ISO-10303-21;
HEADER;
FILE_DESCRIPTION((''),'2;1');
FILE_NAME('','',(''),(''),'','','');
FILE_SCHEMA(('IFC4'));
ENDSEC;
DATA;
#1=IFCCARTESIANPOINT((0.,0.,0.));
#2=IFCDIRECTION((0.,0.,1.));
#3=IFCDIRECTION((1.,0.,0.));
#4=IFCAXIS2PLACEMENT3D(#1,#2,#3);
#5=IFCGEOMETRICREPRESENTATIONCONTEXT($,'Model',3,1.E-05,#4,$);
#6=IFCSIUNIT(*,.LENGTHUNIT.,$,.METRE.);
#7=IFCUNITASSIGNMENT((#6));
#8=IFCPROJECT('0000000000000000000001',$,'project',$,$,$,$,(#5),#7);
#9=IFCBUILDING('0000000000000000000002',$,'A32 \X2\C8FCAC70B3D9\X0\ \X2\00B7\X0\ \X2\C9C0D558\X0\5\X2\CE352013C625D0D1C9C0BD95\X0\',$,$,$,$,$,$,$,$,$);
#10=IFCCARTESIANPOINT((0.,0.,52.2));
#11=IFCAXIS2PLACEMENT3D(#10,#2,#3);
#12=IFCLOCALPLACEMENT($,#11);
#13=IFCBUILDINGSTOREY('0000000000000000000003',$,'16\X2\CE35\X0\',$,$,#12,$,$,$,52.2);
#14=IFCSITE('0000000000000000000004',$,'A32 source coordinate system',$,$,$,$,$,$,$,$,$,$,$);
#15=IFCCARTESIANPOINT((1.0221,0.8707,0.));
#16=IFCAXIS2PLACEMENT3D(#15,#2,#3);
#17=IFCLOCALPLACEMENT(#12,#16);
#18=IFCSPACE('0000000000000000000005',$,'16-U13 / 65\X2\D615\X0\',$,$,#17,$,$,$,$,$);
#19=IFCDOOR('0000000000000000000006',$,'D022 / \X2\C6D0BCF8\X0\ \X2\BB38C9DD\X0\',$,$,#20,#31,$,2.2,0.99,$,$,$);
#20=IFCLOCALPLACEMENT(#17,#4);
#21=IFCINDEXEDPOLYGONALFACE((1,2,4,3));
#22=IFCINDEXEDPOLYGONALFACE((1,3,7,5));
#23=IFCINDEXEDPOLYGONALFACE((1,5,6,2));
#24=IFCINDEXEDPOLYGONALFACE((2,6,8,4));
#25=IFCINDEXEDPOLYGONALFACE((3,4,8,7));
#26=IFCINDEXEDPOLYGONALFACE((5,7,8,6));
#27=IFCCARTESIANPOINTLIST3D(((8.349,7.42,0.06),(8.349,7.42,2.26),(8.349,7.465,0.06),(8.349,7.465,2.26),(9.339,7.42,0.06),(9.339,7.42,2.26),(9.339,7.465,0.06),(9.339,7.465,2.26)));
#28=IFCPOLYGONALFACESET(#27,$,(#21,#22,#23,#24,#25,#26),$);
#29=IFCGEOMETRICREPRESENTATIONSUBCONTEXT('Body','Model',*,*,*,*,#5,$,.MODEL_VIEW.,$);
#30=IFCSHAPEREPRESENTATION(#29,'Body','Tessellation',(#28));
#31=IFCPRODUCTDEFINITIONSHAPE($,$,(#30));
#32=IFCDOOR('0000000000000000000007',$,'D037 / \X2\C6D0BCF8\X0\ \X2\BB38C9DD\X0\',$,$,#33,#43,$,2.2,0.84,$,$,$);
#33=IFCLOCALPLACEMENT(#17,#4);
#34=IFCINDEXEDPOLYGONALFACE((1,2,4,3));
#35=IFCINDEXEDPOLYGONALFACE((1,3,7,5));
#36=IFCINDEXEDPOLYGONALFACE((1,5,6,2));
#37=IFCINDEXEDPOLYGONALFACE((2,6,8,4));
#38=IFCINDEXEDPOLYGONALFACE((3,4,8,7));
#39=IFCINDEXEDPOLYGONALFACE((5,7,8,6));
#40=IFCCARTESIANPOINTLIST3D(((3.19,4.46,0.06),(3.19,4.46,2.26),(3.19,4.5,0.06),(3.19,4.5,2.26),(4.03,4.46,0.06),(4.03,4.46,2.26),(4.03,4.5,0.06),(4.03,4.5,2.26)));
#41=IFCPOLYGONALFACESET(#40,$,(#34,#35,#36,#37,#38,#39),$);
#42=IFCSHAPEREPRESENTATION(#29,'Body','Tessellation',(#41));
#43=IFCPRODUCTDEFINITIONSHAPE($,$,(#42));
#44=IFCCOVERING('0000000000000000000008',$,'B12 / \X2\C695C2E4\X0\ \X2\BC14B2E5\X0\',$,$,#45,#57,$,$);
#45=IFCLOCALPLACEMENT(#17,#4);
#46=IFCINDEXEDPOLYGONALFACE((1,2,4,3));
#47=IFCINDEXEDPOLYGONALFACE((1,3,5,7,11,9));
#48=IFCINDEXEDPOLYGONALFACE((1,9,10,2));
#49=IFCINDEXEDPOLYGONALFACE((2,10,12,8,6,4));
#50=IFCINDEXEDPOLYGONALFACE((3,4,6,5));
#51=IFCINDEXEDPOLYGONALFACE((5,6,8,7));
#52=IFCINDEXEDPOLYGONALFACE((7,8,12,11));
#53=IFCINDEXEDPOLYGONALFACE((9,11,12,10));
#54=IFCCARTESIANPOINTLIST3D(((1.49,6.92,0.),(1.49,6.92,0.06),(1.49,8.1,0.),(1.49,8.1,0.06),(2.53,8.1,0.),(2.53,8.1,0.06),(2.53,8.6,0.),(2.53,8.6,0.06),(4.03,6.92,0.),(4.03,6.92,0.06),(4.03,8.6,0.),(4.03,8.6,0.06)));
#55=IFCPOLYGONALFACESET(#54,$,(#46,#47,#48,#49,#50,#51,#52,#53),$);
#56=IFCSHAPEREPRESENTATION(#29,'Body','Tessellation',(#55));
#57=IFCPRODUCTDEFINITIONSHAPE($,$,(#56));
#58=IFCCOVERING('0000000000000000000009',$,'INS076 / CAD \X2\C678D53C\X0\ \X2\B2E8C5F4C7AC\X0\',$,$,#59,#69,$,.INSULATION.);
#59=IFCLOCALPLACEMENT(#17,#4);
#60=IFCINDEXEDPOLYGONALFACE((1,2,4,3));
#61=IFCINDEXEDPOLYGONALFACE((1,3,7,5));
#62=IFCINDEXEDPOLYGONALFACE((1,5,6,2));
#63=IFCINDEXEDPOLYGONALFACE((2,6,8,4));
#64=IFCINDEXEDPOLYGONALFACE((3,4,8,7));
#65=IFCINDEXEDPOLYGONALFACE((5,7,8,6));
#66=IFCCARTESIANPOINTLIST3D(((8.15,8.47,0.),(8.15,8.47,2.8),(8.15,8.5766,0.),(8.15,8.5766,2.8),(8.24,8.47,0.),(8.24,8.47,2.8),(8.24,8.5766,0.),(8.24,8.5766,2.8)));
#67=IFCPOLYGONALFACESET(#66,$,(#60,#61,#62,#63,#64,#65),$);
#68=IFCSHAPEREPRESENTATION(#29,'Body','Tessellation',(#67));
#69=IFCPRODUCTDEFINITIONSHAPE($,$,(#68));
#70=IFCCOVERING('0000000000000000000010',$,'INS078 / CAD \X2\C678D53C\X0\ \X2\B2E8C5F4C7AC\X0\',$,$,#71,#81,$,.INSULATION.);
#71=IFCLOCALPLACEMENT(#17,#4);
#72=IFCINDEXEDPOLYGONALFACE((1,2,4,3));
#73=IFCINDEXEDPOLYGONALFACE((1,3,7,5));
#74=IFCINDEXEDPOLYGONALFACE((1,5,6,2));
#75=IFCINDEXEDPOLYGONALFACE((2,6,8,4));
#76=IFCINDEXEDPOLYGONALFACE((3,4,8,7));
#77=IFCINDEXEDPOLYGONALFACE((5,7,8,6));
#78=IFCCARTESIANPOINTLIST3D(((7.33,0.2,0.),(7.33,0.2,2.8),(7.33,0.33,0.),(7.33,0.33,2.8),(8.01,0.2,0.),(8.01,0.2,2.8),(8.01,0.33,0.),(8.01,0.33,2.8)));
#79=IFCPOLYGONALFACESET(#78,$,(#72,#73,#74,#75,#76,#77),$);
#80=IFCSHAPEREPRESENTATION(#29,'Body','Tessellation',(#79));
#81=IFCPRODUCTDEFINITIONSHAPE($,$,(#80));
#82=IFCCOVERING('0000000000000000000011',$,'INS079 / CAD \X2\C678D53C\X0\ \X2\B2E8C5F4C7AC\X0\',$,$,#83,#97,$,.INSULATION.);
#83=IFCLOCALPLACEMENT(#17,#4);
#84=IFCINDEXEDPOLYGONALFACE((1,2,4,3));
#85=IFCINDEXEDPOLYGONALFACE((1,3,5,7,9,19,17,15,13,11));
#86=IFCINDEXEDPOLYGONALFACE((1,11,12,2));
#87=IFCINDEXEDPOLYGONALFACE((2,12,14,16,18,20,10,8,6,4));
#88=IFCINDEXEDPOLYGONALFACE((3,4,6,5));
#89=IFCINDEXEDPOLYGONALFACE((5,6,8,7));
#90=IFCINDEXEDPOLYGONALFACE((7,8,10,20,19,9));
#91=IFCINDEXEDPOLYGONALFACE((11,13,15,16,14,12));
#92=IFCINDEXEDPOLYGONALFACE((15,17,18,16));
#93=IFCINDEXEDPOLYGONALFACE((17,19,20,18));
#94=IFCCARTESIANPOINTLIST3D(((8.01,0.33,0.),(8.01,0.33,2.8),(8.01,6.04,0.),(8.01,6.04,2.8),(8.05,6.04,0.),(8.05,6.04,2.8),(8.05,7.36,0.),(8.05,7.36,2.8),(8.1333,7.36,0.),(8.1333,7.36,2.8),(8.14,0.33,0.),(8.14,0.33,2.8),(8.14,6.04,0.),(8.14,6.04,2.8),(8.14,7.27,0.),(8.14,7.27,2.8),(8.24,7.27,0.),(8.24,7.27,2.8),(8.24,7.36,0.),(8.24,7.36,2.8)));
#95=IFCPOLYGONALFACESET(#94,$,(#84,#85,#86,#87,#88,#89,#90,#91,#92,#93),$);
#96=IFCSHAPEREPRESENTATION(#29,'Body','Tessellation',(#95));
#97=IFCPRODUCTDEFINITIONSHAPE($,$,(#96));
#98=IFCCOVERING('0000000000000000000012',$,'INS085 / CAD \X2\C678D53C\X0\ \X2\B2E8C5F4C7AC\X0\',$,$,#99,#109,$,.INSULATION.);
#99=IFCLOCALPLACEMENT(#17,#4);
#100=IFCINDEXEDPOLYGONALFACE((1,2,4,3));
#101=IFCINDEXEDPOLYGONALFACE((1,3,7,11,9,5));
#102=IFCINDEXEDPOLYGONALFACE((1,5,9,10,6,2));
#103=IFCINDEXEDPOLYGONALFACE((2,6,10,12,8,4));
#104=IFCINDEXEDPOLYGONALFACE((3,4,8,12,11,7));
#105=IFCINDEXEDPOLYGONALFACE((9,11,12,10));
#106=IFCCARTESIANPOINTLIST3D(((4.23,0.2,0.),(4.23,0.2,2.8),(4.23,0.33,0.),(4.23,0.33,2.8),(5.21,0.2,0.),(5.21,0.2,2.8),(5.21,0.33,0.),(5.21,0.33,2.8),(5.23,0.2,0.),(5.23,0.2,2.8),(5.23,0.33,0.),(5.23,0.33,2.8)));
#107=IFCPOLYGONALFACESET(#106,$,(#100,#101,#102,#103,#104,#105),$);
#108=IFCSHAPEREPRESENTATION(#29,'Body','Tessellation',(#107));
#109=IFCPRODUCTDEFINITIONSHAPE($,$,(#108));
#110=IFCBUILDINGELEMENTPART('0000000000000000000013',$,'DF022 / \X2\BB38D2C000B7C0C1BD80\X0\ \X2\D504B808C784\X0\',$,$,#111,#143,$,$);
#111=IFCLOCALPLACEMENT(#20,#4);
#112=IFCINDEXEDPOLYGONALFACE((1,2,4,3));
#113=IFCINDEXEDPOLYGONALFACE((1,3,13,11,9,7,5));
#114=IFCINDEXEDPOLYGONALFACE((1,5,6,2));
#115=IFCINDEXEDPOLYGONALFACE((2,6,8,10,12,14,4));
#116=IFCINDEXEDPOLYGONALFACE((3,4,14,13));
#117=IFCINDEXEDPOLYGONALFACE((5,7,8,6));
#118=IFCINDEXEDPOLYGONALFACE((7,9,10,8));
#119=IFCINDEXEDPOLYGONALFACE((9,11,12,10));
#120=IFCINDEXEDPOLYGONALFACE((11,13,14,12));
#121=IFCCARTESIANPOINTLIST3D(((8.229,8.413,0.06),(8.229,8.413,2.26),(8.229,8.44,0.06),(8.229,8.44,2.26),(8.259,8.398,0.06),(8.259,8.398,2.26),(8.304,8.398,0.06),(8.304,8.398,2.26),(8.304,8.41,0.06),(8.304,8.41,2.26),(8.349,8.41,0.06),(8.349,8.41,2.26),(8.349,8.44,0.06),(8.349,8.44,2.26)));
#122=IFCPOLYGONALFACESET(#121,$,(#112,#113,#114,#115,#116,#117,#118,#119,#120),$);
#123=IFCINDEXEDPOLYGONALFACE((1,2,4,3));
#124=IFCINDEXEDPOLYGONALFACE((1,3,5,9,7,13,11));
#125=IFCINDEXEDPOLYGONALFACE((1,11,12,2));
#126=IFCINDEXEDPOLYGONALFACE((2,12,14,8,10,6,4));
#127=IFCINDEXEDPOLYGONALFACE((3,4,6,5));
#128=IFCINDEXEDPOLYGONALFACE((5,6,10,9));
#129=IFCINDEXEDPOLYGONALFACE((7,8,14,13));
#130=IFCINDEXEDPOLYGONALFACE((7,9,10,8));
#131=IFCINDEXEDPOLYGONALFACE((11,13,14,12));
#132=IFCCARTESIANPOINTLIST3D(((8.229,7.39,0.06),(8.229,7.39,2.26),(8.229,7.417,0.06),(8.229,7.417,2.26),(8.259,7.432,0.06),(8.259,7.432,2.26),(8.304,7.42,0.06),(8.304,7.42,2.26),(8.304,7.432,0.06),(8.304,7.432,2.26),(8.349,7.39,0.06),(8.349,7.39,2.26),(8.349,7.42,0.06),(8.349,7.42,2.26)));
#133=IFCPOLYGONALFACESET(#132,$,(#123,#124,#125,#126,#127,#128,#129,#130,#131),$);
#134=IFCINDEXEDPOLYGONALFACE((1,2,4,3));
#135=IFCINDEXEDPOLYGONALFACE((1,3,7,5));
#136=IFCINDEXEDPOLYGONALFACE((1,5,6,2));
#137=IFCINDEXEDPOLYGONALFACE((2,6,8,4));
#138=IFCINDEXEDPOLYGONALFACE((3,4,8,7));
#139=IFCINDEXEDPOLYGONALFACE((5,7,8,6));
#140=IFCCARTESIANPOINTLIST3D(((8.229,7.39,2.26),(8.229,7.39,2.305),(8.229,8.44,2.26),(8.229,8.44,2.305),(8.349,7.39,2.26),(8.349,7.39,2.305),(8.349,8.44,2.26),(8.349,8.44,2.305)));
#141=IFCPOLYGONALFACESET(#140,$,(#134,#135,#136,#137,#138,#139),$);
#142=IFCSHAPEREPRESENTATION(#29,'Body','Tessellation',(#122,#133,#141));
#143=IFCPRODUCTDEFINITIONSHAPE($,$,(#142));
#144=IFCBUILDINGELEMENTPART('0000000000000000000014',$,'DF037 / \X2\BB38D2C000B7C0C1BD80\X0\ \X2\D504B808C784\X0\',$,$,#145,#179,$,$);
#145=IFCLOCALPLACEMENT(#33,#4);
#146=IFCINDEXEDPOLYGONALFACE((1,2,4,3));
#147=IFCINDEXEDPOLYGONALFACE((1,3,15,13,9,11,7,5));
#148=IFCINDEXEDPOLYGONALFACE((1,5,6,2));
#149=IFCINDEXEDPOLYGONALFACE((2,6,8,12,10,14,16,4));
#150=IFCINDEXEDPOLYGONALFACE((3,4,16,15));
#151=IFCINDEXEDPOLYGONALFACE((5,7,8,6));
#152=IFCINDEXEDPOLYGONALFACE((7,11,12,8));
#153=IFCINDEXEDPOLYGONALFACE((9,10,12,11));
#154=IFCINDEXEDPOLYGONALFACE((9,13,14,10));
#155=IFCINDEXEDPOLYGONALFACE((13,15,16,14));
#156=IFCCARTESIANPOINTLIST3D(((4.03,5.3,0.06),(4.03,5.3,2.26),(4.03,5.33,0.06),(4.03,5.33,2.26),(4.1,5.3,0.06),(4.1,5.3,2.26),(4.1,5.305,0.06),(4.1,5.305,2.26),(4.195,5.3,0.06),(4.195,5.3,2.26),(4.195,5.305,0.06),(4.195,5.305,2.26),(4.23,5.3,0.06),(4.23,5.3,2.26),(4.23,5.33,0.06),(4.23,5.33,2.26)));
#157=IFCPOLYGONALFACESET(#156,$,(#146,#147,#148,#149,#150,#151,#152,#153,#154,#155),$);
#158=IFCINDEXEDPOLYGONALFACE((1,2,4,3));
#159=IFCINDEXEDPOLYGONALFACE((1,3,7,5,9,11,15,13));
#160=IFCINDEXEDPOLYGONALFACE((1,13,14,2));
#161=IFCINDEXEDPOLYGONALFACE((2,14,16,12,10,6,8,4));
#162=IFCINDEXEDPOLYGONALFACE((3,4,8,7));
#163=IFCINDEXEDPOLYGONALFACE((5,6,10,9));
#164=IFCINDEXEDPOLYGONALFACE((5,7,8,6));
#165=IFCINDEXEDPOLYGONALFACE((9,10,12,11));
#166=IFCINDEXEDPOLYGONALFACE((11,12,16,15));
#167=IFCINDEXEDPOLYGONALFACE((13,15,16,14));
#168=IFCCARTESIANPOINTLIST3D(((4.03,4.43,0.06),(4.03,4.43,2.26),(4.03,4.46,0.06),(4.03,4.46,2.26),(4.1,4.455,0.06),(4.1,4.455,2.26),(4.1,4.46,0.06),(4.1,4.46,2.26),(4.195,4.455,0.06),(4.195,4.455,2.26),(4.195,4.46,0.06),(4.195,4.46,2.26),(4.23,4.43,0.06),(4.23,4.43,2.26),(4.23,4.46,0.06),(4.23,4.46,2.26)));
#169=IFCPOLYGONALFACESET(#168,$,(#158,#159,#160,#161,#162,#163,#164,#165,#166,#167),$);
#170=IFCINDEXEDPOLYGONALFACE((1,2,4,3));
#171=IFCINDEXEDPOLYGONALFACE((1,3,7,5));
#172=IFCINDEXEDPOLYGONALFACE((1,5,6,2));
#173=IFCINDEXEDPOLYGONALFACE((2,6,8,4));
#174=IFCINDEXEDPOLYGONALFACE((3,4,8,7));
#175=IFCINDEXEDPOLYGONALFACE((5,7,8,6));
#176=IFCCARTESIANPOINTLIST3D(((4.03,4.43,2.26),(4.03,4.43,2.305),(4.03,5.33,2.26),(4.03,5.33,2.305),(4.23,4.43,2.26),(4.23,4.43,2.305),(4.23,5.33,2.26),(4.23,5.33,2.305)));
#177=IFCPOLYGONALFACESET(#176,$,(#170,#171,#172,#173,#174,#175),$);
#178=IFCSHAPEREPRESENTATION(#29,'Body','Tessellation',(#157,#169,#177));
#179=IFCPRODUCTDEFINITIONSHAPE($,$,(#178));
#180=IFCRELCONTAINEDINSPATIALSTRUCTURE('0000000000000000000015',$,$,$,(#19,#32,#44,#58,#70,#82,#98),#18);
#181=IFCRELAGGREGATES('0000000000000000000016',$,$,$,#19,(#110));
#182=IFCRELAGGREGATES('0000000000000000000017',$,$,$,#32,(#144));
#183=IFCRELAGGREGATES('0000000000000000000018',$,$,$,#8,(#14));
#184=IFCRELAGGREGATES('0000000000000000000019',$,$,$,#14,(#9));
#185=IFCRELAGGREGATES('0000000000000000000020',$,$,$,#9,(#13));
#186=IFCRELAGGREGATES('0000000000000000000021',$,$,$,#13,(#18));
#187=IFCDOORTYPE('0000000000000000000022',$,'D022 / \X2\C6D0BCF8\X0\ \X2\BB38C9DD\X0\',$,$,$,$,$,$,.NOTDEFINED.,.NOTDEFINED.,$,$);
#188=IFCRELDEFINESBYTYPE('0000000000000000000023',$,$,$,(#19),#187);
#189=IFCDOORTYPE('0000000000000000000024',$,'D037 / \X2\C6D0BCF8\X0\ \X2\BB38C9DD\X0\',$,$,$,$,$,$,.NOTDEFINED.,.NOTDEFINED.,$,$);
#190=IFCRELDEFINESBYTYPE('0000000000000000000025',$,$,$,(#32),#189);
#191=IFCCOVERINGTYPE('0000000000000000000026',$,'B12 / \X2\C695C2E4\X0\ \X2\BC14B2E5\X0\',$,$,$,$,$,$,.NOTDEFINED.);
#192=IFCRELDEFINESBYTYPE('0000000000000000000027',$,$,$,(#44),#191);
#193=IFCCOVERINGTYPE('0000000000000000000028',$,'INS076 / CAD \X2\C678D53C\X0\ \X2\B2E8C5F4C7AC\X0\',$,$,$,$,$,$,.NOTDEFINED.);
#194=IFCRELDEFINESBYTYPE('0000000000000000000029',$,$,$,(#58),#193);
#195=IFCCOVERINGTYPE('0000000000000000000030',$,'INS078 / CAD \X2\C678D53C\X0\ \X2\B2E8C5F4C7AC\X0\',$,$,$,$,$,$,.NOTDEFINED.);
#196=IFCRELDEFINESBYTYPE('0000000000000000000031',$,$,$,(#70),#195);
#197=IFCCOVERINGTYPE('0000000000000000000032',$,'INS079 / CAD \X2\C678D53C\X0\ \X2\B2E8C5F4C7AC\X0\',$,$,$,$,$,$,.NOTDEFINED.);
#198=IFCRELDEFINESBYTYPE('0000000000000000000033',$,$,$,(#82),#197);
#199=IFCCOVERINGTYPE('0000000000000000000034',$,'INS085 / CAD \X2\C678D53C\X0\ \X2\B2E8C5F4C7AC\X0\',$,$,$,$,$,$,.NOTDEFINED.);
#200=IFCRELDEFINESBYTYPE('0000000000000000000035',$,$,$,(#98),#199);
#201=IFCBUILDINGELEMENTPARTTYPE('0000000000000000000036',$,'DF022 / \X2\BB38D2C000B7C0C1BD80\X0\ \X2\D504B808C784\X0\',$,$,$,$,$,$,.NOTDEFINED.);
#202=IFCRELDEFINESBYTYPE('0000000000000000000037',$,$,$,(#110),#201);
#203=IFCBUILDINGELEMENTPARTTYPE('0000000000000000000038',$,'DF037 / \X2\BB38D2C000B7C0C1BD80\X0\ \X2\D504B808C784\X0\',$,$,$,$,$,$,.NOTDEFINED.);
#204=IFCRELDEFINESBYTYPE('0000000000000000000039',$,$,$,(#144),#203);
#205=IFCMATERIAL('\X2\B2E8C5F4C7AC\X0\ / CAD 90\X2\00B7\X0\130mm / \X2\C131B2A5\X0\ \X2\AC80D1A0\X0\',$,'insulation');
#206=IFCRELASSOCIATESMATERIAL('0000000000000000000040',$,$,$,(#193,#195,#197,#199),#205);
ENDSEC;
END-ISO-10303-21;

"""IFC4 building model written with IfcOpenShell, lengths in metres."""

from ifc_helpers import new_model, si_unit, frame, origin, origin_with_axes, place, context, subcontext, project, spatial, polyline, outline, extrude, source, transform, mapped, material, type_object, type_shapes, element, aggregate, save


model = new_model("IFC4")

# Units and contexts
model_context = context("Model", 3, precision=1e-05, world=origin_with_axes())
body_context = subcontext(model_context, "Body", "Model", "MODEL_VIEW")
ifc_project = project(units=[si_unit("LENGTHUNIT", "METRE")], contexts=[model_context])

# Site, building, storey
site = spatial("IfcSite", under=ifc_project, Name="A32 source coordinate system")
building = spatial("IfcBuilding", under=site, Name="A32 주거동 · 지하5층–옥탑지붕")
storey_placement = place(None, frame((0.0, 0.0, 52.2), z_axis=(0.0, 0.0, 1.0), x_axis=(1.0, 0.0, 0.0)))
storey = spatial("IfcBuildingStorey", under=building, at=storey_placement, Name="16층", Elevation=52.2)

# Shared definitions
space_placement = place(storey_placement, frame((1.0221, 0.8707, 0.0), z_axis=(0.0, 0.0, 1.0), x_axis=(1.0, 0.0, 0.0)))
space = spatial("IfcSpace", under=storey, at=space_placement, Name="16-U13 / 65형")

# Doors
door_type_1 = type_object("IfcDoorType", Name="D022 / 원본 문짝", OperationType="NOTDEFINED", PredefinedType="NOTDEFINED")
shared_shape_1 = source(origin(), body_context, "Body", "SweptSolid", [
    extrude(outline(polyline([(9.339, 7.465), (9.339, 7.42), (8.349, 7.42), (8.349, 7.465), (9.339, 7.465)])), frame((0.0, 0.0, 0.06)), (0.0, 0.0, 1.0), 2.2),
])
type_shapes(door_type_1, [shared_shape_1])
door_1_placement = place(space_placement, origin_with_axes())
door_1 = element("IfcDoor", 1, at=door_1_placement, inside=space, type_object=door_type_1, Name="D022 / 원본 문짝", OverallHeight=2.2, OverallWidth=0.99, context=body_context, shape_type="MappedRepresentation", body=[
    mapped(shared_shape_1, transform((0.0, 0.0, 0.0), scale=1.0)),
])
door_type_2 = type_object("IfcDoorType", Name="D037 / 원본 문짝", OperationType="NOTDEFINED", PredefinedType="NOTDEFINED")
shared_shape_2 = source(origin(), body_context, "Body", "SweptSolid", [
    extrude(outline(polyline([(4.03, 4.46), (3.19, 4.46), (3.19, 4.5), (4.03, 4.5), (4.03, 4.46)])), frame((0.0, 0.0, 0.06)), (0.0, 0.0, 1.0), 2.2),
])
type_shapes(door_type_2, [shared_shape_2])
door_2_placement = place(space_placement, origin_with_axes())
door_2 = element("IfcDoor", 2, at=door_2_placement, inside=space, type_object=door_type_2, Name="D037 / 원본 문짝", OverallHeight=2.2, OverallWidth=0.84, context=body_context, shape_type="MappedRepresentation", body=[
    mapped(shared_shape_2, transform((0.0, 0.0, 0.0), scale=1.0)),
])

# Coverings
covering_type_1 = type_object("IfcCoveringType", Name="B12 / 욕실 바닥", PredefinedType="NOTDEFINED")
shared_shape_3 = source(origin(), body_context, "Body", "SweptSolid", [
    extrude(outline(polyline([(2.53, 8.6), (4.03, 8.6), (4.03, 6.92), (1.49, 6.92), (1.49, 8.1), (2.53, 8.1), (2.53, 8.6)])), origin(), (0.0, 0.0, 1.0), 0.06),
])
type_shapes(covering_type_1, [shared_shape_3])
covering_1_placement = place(space_placement, origin_with_axes())
element("IfcCovering", 3, at=covering_1_placement, inside=space, type_object=covering_type_1, Name="B12 / 욕실 바닥", context=body_context, shape_type="MappedRepresentation", body=[
    mapped(shared_shape_3, transform((0.0, 0.0, 0.0), scale=1.0)),
])
ifc_material = material(Name="단열재 / CAD 90·130mm / 성능 검토", Category="insulation")
covering_type_2 = type_object("IfcCoveringType", Name="INS076 / CAD 외피 단열재", PredefinedType="NOTDEFINED", material=ifc_material)
shared_shape_4 = source(origin(), body_context, "Body", "SweptSolid", [
    extrude(outline(polyline([(8.24, 8.5766), (8.24, 8.47), (8.15, 8.47), (8.15, 8.5766), (8.24, 8.5766)])), origin(), (0.0, 0.0, 1.0), 2.8),
])
type_shapes(covering_type_2, [shared_shape_4])
covering_2_placement = place(space_placement, origin_with_axes())
element("IfcCovering", 4, at=covering_2_placement, inside=space, type_object=covering_type_2, Name="INS076 / CAD 외피 단열재", PredefinedType="INSULATION", context=body_context, shape_type="MappedRepresentation", body=[
    mapped(shared_shape_4, transform((0.0, 0.0, 0.0), scale=1.0)),
])
covering_type_3 = type_object("IfcCoveringType", Name="INS078 / CAD 외피 단열재", PredefinedType="NOTDEFINED", material=ifc_material)
shared_shape_5 = source(origin(), body_context, "Body", "SweptSolid", [
    extrude(outline(polyline([(8.01, 0.2), (7.33, 0.2), (7.33, 0.33), (8.01, 0.33), (8.01, 0.2)])), origin(), (0.0, 0.0, 1.0), 2.8),
])
type_shapes(covering_type_3, [shared_shape_5])
covering_3_placement = place(space_placement, origin_with_axes())
element("IfcCovering", 5, at=covering_3_placement, inside=space, type_object=covering_type_3, Name="INS078 / CAD 외피 단열재", PredefinedType="INSULATION", context=body_context, shape_type="MappedRepresentation", body=[
    mapped(shared_shape_5, transform((0.0, 0.0, 0.0), scale=1.0)),
])
covering_type_4 = type_object("IfcCoveringType", Name="INS079 / CAD 외피 단열재", PredefinedType="NOTDEFINED", material=ifc_material)
shared_shape_6 = source(origin(), body_context, "Body", "SweptSolid", [
    extrude(outline(polyline([(8.24, 7.27), (8.14, 7.27), (8.14, 6.04), (8.14, 0.33), (8.01, 0.33), (8.01, 6.04), (8.05, 6.04), (8.05, 7.36), (8.1333, 7.36), (8.24, 7.36), (8.24, 7.27)])), origin(), (0.0, 0.0, 1.0), 2.8),
])
type_shapes(covering_type_4, [shared_shape_6])
covering_4_placement = place(space_placement, origin_with_axes())
element("IfcCovering", 6, at=covering_4_placement, inside=space, type_object=covering_type_4, Name="INS079 / CAD 외피 단열재", PredefinedType="INSULATION", context=body_context, shape_type="MappedRepresentation", body=[
    mapped(shared_shape_6, transform((0.0, 0.0, 0.0), scale=1.0)),
])
covering_type_5 = type_object("IfcCoveringType", Name="INS085 / CAD 외피 단열재", PredefinedType="NOTDEFINED", material=ifc_material)
shared_shape_7 = source(origin(), body_context, "Body", "SweptSolid", [
    extrude(outline(polyline([(4.23, 0.2), (4.23, 0.33), (5.21, 0.33), (5.23, 0.33), (5.23, 0.2), (5.21, 0.2), (4.23, 0.2)])), origin(), (0.0, 0.0, 1.0), 2.8),
])
type_shapes(covering_type_5, [shared_shape_7])
covering_5_placement = place(space_placement, origin_with_axes())
element("IfcCovering", 7, at=covering_5_placement, inside=space, type_object=covering_type_5, Name="INS085 / CAD 외피 단열재", PredefinedType="INSULATION", context=body_context, shape_type="MappedRepresentation", body=[
    mapped(shared_shape_7, transform((0.0, 0.0, 0.0), scale=1.0)),
])

# Building element parts
building_element_part_type_1 = type_object("IfcBuildingElementPartType", Name="DF022 / 문틀·상부 프레임", PredefinedType="NOTDEFINED")
shared_shape_8 = source(origin(), body_context, "Body", "SweptSolid", [
    extrude(outline(polyline([(8.349, 8.41), (8.304, 8.41), (8.304, 8.398), (8.259, 8.398), (8.229, 8.413), (8.229, 8.44), (8.349, 8.44), (8.349, 8.41)])), frame((0.0, 0.0, 0.06)), (0.0, 0.0, 1.0), 2.2),
    extrude(outline(polyline([(8.229, 7.39), (8.229, 7.417), (8.259, 7.432), (8.304, 7.432), (8.304, 7.42), (8.349, 7.42), (8.349, 7.39), (8.229, 7.39)])), frame((0.0, 0.0, 0.06)), (0.0, 0.0, 1.0), 2.2),
    extrude(outline(polyline([(8.229, 7.39), (8.229, 8.44), (8.349, 8.44), (8.349, 7.39), (8.229, 7.39)])), frame((0.0, 0.0, 2.26)), (0.0, 0.0, 1.0), 0.045),
])
type_shapes(building_element_part_type_1, [shared_shape_8])
building_element_part_1_placement = place(door_1_placement, origin_with_axes())
building_element_part_1 = element("IfcBuildingElementPart", 8, at=building_element_part_1_placement, type_object=building_element_part_type_1, Name="DF022 / 문틀·상부 프레임", context=body_context, shape_type="MappedRepresentation", body=[
    mapped(shared_shape_8, transform((0.0, 0.0, 0.0), scale=1.0)),
])
aggregate(door_1, [building_element_part_1])
building_element_part_type_2 = type_object("IfcBuildingElementPartType", Name="DF037 / 문틀·상부 프레임", PredefinedType="NOTDEFINED")
shared_shape_9 = source(origin(), body_context, "Body", "SweptSolid", [
    extrude(outline(polyline([(4.23, 5.33), (4.23, 5.3), (4.195, 5.3), (4.195, 5.305), (4.1, 5.305), (4.1, 5.3), (4.03, 5.3), (4.03, 5.33), (4.23, 5.33)])), frame((0.0, 0.0, 0.06)), (0.0, 0.0, 1.0), 2.2),
    extrude(outline(polyline([(4.03, 4.46), (4.1, 4.46), (4.1, 4.455), (4.195, 4.455), (4.195, 4.46), (4.23, 4.46), (4.23, 4.43), (4.03, 4.43), (4.03, 4.46)])), frame((0.0, 0.0, 0.06)), (0.0, 0.0, 1.0), 2.2),
    extrude(outline(polyline([(4.03, 4.43), (4.03, 5.33), (4.23, 5.33), (4.23, 4.43), (4.03, 4.43)])), frame((0.0, 0.0, 2.26)), (0.0, 0.0, 1.0), 0.045),
])
type_shapes(building_element_part_type_2, [shared_shape_9])
building_element_part_2_placement = place(door_2_placement, origin_with_axes())
building_element_part_2 = element("IfcBuildingElementPart", 9, at=building_element_part_2_placement, type_object=building_element_part_type_2, Name="DF037 / 문틀·상부 프레임", context=body_context, shape_type="MappedRepresentation", body=[
    mapped(shared_shape_9, transform((0.0, 0.0, 0.0), scale=1.0)),
])
aggregate(door_2, [building_element_part_2])

save(model, "model.ifc")
